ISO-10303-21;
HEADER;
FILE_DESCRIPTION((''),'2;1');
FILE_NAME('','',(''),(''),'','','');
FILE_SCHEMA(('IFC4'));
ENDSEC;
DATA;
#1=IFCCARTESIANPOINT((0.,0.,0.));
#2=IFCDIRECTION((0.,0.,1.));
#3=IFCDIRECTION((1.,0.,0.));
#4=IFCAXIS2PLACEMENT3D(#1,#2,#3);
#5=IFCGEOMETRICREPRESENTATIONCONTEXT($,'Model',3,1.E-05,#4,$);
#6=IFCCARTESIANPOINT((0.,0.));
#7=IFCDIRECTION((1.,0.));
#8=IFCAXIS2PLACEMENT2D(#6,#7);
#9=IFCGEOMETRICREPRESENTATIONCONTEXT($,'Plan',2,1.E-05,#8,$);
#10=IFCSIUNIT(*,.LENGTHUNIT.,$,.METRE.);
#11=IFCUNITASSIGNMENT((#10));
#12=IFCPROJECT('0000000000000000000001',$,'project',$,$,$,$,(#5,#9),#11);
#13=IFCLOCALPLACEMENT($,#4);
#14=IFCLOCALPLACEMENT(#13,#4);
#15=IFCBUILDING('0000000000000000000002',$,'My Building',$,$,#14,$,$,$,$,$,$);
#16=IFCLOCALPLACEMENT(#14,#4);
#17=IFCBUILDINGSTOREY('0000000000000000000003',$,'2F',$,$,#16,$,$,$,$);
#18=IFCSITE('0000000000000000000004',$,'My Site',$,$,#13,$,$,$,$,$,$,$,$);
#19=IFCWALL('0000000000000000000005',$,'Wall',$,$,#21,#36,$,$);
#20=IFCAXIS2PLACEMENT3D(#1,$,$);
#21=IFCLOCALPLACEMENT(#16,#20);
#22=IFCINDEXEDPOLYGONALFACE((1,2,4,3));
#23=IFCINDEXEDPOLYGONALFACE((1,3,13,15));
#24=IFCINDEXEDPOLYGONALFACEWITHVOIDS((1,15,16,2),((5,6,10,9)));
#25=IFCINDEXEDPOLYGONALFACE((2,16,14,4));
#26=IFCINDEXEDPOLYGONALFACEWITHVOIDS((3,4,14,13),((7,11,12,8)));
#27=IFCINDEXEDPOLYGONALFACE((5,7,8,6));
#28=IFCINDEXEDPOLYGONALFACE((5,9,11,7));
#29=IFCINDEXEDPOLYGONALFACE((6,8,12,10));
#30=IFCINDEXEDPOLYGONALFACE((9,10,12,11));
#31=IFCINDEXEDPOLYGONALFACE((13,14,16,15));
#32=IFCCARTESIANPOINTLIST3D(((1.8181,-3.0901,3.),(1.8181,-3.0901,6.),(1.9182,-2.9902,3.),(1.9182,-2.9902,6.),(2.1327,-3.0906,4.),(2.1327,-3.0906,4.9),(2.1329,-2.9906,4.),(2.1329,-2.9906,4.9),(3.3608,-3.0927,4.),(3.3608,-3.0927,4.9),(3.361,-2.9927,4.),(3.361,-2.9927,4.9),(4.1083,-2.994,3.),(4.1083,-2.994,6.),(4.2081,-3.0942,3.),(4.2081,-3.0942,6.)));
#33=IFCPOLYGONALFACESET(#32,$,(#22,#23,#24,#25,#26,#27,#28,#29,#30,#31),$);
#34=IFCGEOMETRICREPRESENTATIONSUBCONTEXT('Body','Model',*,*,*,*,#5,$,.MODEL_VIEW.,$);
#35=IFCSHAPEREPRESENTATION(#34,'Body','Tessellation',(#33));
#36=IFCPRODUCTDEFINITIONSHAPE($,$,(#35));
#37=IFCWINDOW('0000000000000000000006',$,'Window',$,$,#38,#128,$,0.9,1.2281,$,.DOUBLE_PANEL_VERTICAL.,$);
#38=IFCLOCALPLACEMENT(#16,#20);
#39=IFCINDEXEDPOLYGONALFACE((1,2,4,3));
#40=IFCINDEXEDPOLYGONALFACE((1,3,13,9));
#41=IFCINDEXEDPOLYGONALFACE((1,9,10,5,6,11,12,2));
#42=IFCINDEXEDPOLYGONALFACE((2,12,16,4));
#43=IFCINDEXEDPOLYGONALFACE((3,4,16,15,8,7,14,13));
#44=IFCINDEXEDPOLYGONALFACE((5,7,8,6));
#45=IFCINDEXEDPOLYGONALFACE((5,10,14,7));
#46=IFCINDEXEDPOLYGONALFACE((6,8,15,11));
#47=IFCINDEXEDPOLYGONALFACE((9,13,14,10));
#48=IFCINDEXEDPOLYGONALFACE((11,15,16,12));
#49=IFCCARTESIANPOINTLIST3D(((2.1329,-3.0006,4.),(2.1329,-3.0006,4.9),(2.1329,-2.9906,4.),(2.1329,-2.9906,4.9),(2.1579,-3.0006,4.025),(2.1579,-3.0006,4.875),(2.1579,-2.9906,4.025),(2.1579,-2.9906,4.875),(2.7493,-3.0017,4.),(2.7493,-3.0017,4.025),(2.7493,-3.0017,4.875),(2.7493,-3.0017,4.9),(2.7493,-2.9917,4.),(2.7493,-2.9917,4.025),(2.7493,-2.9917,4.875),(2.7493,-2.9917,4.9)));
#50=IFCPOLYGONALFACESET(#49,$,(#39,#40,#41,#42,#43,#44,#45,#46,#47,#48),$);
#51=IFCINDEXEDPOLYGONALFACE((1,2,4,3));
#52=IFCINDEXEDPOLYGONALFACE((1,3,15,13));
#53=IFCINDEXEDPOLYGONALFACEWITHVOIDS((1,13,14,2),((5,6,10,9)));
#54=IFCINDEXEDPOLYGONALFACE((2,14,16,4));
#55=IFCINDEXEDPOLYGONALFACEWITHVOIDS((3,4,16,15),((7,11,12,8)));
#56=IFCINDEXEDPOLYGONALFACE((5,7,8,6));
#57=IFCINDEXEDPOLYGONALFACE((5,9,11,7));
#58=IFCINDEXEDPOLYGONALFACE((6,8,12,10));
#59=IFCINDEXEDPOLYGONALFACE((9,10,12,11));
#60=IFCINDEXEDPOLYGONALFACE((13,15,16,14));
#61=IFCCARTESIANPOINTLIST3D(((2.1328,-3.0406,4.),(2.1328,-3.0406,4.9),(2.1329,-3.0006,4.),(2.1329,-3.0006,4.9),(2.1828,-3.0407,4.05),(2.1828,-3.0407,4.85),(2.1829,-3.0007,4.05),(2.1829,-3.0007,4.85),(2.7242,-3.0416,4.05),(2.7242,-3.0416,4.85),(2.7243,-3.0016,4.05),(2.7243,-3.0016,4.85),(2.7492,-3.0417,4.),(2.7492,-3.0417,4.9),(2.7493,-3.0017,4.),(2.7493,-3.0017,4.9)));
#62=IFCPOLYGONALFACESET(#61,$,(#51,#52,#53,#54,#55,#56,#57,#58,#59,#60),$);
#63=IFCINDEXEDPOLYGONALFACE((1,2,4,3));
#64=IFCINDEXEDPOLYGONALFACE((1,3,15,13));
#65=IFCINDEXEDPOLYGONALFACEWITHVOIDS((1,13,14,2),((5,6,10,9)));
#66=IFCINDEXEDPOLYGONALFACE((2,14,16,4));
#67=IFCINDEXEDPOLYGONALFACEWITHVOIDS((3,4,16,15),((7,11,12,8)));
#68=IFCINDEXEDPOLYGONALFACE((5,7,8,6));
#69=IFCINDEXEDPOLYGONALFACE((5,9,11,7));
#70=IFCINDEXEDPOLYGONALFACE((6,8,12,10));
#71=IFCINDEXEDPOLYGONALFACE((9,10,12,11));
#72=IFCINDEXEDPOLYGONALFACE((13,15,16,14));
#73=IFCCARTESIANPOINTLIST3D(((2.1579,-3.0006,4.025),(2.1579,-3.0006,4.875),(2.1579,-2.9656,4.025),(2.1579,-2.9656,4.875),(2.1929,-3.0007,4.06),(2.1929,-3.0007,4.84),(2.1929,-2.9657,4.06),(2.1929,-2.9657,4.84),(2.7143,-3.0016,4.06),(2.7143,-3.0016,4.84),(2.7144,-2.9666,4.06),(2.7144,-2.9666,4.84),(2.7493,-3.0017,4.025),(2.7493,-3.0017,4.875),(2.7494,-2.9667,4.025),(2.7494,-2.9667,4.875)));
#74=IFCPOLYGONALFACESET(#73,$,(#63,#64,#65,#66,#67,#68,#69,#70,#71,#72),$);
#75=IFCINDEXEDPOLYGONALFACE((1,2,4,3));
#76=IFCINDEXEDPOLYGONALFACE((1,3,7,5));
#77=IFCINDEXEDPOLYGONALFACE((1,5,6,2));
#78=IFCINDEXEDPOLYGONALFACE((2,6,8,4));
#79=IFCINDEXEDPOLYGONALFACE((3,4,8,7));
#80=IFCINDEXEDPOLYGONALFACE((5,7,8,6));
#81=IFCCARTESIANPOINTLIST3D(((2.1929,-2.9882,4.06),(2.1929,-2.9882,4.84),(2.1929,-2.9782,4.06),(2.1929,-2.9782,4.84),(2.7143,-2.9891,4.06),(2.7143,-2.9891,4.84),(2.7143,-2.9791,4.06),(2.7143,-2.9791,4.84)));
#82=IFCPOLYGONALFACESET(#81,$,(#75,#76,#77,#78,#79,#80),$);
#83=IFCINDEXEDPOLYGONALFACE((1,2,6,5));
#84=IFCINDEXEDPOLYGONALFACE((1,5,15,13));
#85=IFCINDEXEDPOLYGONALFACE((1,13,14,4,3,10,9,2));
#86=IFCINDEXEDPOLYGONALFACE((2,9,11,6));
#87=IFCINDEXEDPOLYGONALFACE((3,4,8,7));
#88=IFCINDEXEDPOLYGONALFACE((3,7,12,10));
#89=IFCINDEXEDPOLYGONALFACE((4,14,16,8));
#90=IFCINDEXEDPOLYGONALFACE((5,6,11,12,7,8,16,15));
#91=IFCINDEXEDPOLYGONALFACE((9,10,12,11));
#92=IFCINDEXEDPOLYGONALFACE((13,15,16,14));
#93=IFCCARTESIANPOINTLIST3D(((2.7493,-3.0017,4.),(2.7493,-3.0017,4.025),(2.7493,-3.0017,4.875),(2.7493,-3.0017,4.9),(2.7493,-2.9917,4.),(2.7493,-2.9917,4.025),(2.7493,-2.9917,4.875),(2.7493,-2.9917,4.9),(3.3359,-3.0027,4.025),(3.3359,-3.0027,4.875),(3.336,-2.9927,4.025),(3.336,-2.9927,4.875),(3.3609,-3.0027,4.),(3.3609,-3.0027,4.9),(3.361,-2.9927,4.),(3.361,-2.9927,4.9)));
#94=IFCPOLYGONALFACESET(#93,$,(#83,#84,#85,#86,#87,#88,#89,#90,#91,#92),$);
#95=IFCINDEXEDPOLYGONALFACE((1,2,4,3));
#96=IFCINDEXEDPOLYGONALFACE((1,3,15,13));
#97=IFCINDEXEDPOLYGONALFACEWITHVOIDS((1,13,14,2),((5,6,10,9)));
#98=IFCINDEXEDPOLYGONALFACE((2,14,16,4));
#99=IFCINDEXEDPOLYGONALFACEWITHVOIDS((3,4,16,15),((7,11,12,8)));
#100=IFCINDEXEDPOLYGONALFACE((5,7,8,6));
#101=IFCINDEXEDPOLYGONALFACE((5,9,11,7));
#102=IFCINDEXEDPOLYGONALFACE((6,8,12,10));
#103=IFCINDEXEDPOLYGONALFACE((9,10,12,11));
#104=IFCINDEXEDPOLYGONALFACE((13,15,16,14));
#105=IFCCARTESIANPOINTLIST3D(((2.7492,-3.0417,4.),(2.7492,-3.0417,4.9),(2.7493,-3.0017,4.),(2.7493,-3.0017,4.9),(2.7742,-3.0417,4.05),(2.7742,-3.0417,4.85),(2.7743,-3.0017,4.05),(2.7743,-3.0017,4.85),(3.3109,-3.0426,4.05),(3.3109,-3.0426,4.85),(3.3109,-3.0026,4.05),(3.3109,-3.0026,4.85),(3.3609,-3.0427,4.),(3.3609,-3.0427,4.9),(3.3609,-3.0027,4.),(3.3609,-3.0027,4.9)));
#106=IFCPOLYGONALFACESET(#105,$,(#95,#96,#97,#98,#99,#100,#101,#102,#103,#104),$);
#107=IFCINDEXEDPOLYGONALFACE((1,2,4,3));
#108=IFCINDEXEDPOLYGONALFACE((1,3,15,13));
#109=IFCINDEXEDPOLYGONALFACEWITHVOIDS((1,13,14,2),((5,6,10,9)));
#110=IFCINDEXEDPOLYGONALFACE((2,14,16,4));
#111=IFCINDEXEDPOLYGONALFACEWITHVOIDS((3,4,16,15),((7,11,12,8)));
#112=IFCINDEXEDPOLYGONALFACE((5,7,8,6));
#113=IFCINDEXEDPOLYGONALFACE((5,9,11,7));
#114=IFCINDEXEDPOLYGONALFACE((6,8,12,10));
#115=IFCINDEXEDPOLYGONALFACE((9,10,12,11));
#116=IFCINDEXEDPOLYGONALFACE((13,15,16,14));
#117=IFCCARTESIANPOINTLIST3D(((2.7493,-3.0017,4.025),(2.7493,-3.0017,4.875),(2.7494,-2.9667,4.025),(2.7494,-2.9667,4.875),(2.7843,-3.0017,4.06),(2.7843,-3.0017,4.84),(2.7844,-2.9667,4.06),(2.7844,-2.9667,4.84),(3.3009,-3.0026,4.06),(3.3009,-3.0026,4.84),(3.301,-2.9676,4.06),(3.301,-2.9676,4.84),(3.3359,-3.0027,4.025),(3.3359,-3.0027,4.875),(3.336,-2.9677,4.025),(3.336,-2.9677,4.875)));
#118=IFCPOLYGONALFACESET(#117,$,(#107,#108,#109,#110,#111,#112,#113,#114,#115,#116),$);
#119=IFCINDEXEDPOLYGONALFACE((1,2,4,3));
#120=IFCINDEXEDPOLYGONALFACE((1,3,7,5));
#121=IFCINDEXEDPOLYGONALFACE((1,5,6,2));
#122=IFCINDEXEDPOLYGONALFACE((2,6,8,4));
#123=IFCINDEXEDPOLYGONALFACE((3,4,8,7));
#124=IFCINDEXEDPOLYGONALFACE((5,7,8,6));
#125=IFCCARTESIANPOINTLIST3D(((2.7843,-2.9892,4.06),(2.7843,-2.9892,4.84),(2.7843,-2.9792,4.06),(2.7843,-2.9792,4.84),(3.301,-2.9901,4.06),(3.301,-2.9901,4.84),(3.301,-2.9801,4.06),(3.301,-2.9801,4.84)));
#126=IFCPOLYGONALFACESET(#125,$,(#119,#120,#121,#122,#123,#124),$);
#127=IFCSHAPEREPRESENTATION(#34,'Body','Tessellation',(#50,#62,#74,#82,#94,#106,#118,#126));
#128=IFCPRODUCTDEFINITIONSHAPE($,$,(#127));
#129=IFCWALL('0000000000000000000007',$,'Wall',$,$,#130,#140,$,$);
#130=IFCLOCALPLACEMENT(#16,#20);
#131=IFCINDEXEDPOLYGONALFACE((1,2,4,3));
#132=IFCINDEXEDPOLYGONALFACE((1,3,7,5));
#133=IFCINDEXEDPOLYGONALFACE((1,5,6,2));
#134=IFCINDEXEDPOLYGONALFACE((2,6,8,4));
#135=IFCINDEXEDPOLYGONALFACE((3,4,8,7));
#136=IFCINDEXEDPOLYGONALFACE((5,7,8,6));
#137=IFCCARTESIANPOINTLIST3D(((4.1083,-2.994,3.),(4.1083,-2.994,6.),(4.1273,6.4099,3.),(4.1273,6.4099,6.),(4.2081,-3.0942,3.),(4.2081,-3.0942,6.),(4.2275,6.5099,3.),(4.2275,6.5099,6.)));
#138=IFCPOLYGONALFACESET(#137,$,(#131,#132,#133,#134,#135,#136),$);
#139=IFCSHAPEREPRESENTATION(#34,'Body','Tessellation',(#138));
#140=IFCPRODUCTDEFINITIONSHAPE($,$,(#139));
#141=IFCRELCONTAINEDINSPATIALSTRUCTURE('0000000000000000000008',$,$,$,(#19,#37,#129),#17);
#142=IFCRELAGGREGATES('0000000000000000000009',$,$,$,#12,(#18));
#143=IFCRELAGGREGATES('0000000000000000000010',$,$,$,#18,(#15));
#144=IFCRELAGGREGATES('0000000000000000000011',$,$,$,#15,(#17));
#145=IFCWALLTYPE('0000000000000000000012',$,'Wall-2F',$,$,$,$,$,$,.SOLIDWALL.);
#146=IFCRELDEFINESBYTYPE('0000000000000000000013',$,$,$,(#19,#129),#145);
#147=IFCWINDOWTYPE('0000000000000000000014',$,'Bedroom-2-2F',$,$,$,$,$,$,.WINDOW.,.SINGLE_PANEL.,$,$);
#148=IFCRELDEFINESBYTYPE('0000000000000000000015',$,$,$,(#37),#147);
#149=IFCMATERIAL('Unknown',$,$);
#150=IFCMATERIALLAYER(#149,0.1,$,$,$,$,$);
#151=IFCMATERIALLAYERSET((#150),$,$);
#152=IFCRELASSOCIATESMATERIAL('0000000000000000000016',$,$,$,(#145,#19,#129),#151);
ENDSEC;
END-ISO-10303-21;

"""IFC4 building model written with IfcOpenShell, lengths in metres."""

from ifc_helpers import new_model, entity, si_unit, frame, origin_with_axes, origin_2d_with_axis, place, context, subcontext, project, spatial, line, indexed_curve, outline, extrude, shape, source, transform, mapped, material, layer, layer_set, layer_usage, type_object, type_shapes, element, fill, save


model = new_model("IFC4")

# Units and contexts
model_context = context("Model", 3, precision=1e-05, world=origin_with_axes())
plan_context = context("Plan", 2, precision=1e-05, world=origin_2d_with_axis())
body_context_1 = subcontext(model_context, "Body", "Model", "MODEL_VIEW")
body_context_2 = subcontext(plan_context, "Body", "Plan", "PLAN_VIEW")
ifc_project = project(units=[si_unit("LENGTHUNIT", "METRE")], contexts=[model_context, plan_context])

# Site, building, storey
site_placement = place(None, origin_with_axes())
site = spatial("IfcSite", under=ifc_project, at=site_placement, Name="My Site")
building_placement = place(site_placement, origin_with_axes())
building = spatial("IfcBuilding", under=site, at=building_placement, Name="My Building")
storey_placement = place(building_placement, origin_with_axes())
storey = spatial("IfcBuildingStorey", under=building, at=storey_placement, Name="2F")

# Shared definitions
ifc_material = material(Name="Unknown")

# Shared definitions
ifc_layer_1 = layer(ifc_material, 0.1)
ifc_layer_set_1 = layer_set([ifc_layer_1])
wall_type = type_object("IfcWallType", Name="Wall-2F", PredefinedType="SOLIDWALL", material=ifc_layer_set_1)

# Wall, opening, window
ifc_layer_usage_1 = layer_usage(ifc_layer_set_1, "AXIS2", "POSITIVE", 0.0)
wall_1_placement = place(storey_placement, frame((1.8181, -3.0901, 3.0), z_axis=(0.0, 0.0, 1.0), x_axis=(0.999999, -0.001718, 0.0)))
wall_1 = element("IfcWall", 1, at=wall_1_placement, inside=storey, type_object=wall_type, material=ifc_layer_usage_1, Name="Wall", context=body_context_1, shape_type="SweptSolid", body=[
    extrude(outline(indexed_curve([(0.0, 0.0), (0.1, 0.1), (2.29, 0.1), (2.39, 0.0)], segments=[line(1, 2, 3, 4, 1)])), origin_with_axes(), (0.0, 0.0, 1.0), 3.0),
])
shared_shape_1 = source(origin_with_axes(), body_context_1, "Body", "SweptSolid", [
    extrude(outline(indexed_curve([(0.0, 0.0), (1.2281, 0.0), (1.2281, 0.9), (0.0, 0.9)], segments=[line(1, 2, 3, 4, 1)])), frame((0.0, -0.6, 0.0), z_axis=(0.0, -1.0, 0.0), x_axis=(1.0, 0.0, 0.0)), (0.0, 0.0, -1.0), 1.2),
])
opening_1_placement = place(wall_1_placement, frame((0.3146, 0.0, 1.0), z_axis=(0.0, 0.0, 1.0), x_axis=(1.0, -0.000001, 0.0)))
opening_1 = element("IfcOpeningElement", 2, at=opening_1_placement, cuts=wall_1, PredefinedType="OPENING", context=body_context_1, shape_type="MappedRepresentation", body=[
    mapped(shared_shape_1, transform((0.0, 0.0, 0.0), x_axis=(1.0, 0.0, 0.0), y_axis=(0.0, 1.0, 0.0), z_axis=(0.0, 0.0, 1.0), scale=1.0)),
])
window_type = type_object("IfcWindowType", Name="Bedroom-2-2F", PartitioningType="SINGLE_PANEL", PredefinedType="WINDOW")
shared_shape_2 = source(origin_with_axes(), body_context_1, "Body", "SweptSolid", [
    extrude(outline(indexed_curve([(0.6164, 0.0), (0.0, 0.0), (0.0, 0.9), (0.6164, 0.9), (0.6164, 0.875), (0.025, 0.875), (0.025, 0.025), (0.6164, 0.025)], segments=[line(1, 2, 3, 4, 5, 6, 7, 8, 1)])), frame((0.0, 0.09, 0.0), z_axis=(0.0, -1.0, 0.0), x_axis=(1.0, 0.0, 0.0)), (0.0, 0.0, -1.0), 0.01),
    extrude(outline(indexed_curve([(0.0, 0.0), (0.6164, 0.0), (0.6164, 0.9), (0.0, 0.9)], segments=[line(1, 2, 3, 4, 1)]), holes=[indexed_curve([(0.05, 0.05), (0.5914, 0.05), (0.5914, 0.85), (0.05, 0.85)], segments=[line(1, 2, 3, 4, 1)])]), frame((0.0, 0.05, 0.0), z_axis=(0.0, -1.0, 0.0), x_axis=(1.0, 0.0, 0.0)), (0.0, 0.0, -1.0), 0.04),
    extrude(outline(indexed_curve([(0.0, 0.0), (0.5914, 0.0), (0.5914, 0.85), (0.0, 0.85)], segments=[line(1, 2, 3, 4, 1)]), holes=[indexed_curve([(0.035, 0.035), (0.5564, 0.035), (0.5564, 0.815), (0.035, 0.815)], segments=[line(1, 2, 3, 4, 1)])]), frame((0.025, 0.09, 0.025), z_axis=(0.0, -1.0, 0.0), x_axis=(1.0, 0.0, 0.0)), (0.0, 0.0, -1.0), 0.035),
    extrude(outline(indexed_curve([(0.035, 0.035), (0.5564, 0.035), (0.5564, 0.815), (0.035, 0.815)], segments=[line(1, 2, 3, 4, 1)])), frame((0.025, 0.1025, 0.025), z_axis=(0.0, -1.0, 0.0), x_axis=(1.0, 0.0, 0.0)), (0.0, 0.0, -1.0), 0.01),
    extrude(outline(indexed_curve([(0.0, 0.9), (0.6116, 0.9), (0.6116, 0.0), (0.0, 0.0), (0.0, 0.025), (0.5866, 0.025), (0.5866, 0.875), (0.0, 0.875)], segments=[line(1, 2, 3, 4, 5, 6, 7, 8, 1)])), frame((0.6164, 0.09, 0.0), z_axis=(0.0, -1.0, 0.0), x_axis=(1.0, 0.0, 0.0)), (0.0, 0.0, -1.0), 0.01),
    extrude(outline(indexed_curve([(0.0, 0.0), (0.6116, 0.0), (0.6116, 0.9), (0.0, 0.9)], segments=[line(1, 2, 3, 4, 1)]), holes=[indexed_curve([(0.025, 0.05), (0.5616, 0.05), (0.5616, 0.85), (0.025, 0.85)], segments=[line(1, 2, 3, 4, 1)])]), frame((0.6164, 0.05, 0.0), z_axis=(0.0, -1.0, 0.0), x_axis=(1.0, 0.0, 0.0)), (0.0, 0.0, -1.0), 0.04),
    extrude(outline(indexed_curve([(0.0, 0.0), (0.5866, 0.0), (0.5866, 0.85), (0.0, 0.85)], segments=[line(1, 2, 3, 4, 1)]), holes=[indexed_curve([(0.035, 0.035), (0.5516, 0.035), (0.5516, 0.815), (0.035, 0.815)], segments=[line(1, 2, 3, 4, 1)])]), frame((0.6164, 0.09, 0.025), z_axis=(0.0, -1.0, 0.0), x_axis=(1.0, 0.0, 0.0)), (0.0, 0.0, -1.0), 0.035),
    extrude(outline(indexed_curve([(0.035, 0.035), (0.5516, 0.035), (0.5516, 0.815), (0.035, 0.815)], segments=[line(1, 2, 3, 4, 1)])), frame((0.6164, 0.1025, 0.025), z_axis=(0.0, -1.0, 0.0), x_axis=(1.0, 0.0, 0.0)), (0.0, 0.0, -1.0), 0.01),
])
shared_shape_3 = source(origin_with_axes(), body_context_2, "Body", "Curve2D", [
    entity("IfcIndexedPolyCurve", entity("IfcCartesianPointList2D", [[0.05, 0.05], [0.5914, 0.05]])),
    entity("IfcIndexedPolyCurve", entity("IfcCartesianPointList2D", [[0.0, 0.1], [0.025, 0.1], [0.025, 0.09], [0.05, 0.09], [0.05, 0.05], [0.0, 0.05]]), [entity("IfcLineIndex", [1, 2, 3, 4, 5, 6, 1])]),
    entity("IfcIndexedPolyCurve", entity("IfcCartesianPointList2D", [[0.6164, 0.1], [0.6164, 0.1], [0.6164, 0.09], [0.5914, 0.09], [0.5914, 0.05], [0.6164, 0.05]])),
    entity("IfcIndexedPolyCurve", entity("IfcCartesianPointList2D", [[0.025, 0.09], [0.06, 0.09], [0.06, 0.125], [0.025, 0.125]]), [entity("IfcLineIndex", [1, 2, 3, 4, 1])]),
    entity("IfcIndexedPolyCurve", entity("IfcCartesianPointList2D", [[0.6164, 0.09], [0.5814, 0.09], [0.5814, 0.125], [0.6164, 0.125]]), [entity("IfcLineIndex", [1, 2, 3, 4, 1])]),
    entity("IfcIndexedPolyCurve", entity("IfcCartesianPointList2D", [[0.06, 0.09], [0.5814, 0.09]])),
    entity("IfcIndexedPolyCurve", entity("IfcCartesianPointList2D", [[0.06, 0.125], [0.5814, 0.125]])),
    entity("IfcIndexedPolyCurve", entity("IfcCartesianPointList2D", [[0.06, 0.1075], [0.5814, 0.1075]])),
    entity("IfcIndexedPolyCurve", entity("IfcCartesianPointList2D", [[0.6414, 0.05], [1.1781, 0.05]])),
    entity("IfcIndexedPolyCurve", entity("IfcCartesianPointList2D", [[0.6164, 0.1], [0.6164, 0.1], [0.6164, 0.09], [0.6414, 0.09], [0.6414, 0.05], [0.6164, 0.05]])),
    entity("IfcIndexedPolyCurve", entity("IfcCartesianPointList2D", [[1.2281, 0.1], [1.2031, 0.1], [1.2031, 0.09], [1.1781, 0.09], [1.1781, 0.05], [1.2281, 0.05]]), [entity("IfcLineIndex", [1, 2, 3, 4, 5, 6, 1])]),
    entity("IfcIndexedPolyCurve", entity("IfcCartesianPointList2D", [[0.6164, 0.09], [0.6514, 0.09], [0.6514, 0.125], [0.6164, 0.125]]), [entity("IfcLineIndex", [1, 2, 3, 4, 1])]),
    entity("IfcIndexedPolyCurve", entity("IfcCartesianPointList2D", [[1.2031, 0.09], [1.1681, 0.09], [1.1681, 0.125], [1.2031, 0.125]]), [entity("IfcLineIndex", [1, 2, 3, 4, 1])]),
    entity("IfcIndexedPolyCurve", entity("IfcCartesianPointList2D", [[0.6514, 0.09], [1.1681, 0.09]])),
    entity("IfcIndexedPolyCurve", entity("IfcCartesianPointList2D", [[0.6514, 0.125], [1.1681, 0.125]])),
    entity("IfcIndexedPolyCurve", entity("IfcCartesianPointList2D", [[0.6514, 0.1075], [1.1681, 0.1075]])),
])
type_shapes(window_type, [shared_shape_2, shared_shape_3])
window_placement = place(opening_1_placement, frame((0.0, 0.0, 0.0), z_axis=(0.0, 0.0, 1.0), x_axis=(1.0, 0.0, 0.0)))
window = element("IfcWindow", 3, at=window_placement, inside=storey, type_object=window_type, Name="Window", OverallHeight=0.9, OverallWidth=1.2281, PartitioningType="DOUBLE_PANEL_VERTICAL", shapes=[
    shape(body_context_1, "Body", "MappedRepresentation", [mapped(shared_shape_2, transform((0.0, 0.0, 0.0), x_axis=(1.0, 0.0, 0.0), y_axis=(0.0, 1.0, 0.0), z_axis=(0.0, 0.0, 1.0), scale=1.0))]),
    shape(body_context_2, "Body", "MappedRepresentation", [mapped(shared_shape_3, transform((0.0, 0.0, 0.0), x_axis=(1.0, 0.0, 0.0), y_axis=(0.0, 1.0, 0.0), z_axis=(0.0, 0.0, 1.0), scale=1.0))]),
])
fill(opening_1, window)

# Wall
ifc_layer_usage_2 = layer_usage(ifc_layer_set_1, "AXIS2", "POSITIVE", 0.0)
wall_2_placement = place(storey_placement, frame((4.2081, -3.0942, 3.0), z_axis=(0.0, 0.0, 1.0), x_axis=(0.002021, 0.999998, 0.0)))
element("IfcWall", 4, at=wall_2_placement, inside=storey, type_object=wall_type, material=ifc_layer_usage_2, Name="Wall", context=body_context_1, shape_type="SweptSolid", body=[
    extrude(outline(indexed_curve([(0.0, 0.0), (0.1, 0.1), (9.5039, 0.1), (9.6041, 0.0)], segments=[line(1, 2, 3, 4, 1)])), origin_with_axes(), (0.0, 0.0, 1.0), 3.0),
])

save(model, "model.ifc")
